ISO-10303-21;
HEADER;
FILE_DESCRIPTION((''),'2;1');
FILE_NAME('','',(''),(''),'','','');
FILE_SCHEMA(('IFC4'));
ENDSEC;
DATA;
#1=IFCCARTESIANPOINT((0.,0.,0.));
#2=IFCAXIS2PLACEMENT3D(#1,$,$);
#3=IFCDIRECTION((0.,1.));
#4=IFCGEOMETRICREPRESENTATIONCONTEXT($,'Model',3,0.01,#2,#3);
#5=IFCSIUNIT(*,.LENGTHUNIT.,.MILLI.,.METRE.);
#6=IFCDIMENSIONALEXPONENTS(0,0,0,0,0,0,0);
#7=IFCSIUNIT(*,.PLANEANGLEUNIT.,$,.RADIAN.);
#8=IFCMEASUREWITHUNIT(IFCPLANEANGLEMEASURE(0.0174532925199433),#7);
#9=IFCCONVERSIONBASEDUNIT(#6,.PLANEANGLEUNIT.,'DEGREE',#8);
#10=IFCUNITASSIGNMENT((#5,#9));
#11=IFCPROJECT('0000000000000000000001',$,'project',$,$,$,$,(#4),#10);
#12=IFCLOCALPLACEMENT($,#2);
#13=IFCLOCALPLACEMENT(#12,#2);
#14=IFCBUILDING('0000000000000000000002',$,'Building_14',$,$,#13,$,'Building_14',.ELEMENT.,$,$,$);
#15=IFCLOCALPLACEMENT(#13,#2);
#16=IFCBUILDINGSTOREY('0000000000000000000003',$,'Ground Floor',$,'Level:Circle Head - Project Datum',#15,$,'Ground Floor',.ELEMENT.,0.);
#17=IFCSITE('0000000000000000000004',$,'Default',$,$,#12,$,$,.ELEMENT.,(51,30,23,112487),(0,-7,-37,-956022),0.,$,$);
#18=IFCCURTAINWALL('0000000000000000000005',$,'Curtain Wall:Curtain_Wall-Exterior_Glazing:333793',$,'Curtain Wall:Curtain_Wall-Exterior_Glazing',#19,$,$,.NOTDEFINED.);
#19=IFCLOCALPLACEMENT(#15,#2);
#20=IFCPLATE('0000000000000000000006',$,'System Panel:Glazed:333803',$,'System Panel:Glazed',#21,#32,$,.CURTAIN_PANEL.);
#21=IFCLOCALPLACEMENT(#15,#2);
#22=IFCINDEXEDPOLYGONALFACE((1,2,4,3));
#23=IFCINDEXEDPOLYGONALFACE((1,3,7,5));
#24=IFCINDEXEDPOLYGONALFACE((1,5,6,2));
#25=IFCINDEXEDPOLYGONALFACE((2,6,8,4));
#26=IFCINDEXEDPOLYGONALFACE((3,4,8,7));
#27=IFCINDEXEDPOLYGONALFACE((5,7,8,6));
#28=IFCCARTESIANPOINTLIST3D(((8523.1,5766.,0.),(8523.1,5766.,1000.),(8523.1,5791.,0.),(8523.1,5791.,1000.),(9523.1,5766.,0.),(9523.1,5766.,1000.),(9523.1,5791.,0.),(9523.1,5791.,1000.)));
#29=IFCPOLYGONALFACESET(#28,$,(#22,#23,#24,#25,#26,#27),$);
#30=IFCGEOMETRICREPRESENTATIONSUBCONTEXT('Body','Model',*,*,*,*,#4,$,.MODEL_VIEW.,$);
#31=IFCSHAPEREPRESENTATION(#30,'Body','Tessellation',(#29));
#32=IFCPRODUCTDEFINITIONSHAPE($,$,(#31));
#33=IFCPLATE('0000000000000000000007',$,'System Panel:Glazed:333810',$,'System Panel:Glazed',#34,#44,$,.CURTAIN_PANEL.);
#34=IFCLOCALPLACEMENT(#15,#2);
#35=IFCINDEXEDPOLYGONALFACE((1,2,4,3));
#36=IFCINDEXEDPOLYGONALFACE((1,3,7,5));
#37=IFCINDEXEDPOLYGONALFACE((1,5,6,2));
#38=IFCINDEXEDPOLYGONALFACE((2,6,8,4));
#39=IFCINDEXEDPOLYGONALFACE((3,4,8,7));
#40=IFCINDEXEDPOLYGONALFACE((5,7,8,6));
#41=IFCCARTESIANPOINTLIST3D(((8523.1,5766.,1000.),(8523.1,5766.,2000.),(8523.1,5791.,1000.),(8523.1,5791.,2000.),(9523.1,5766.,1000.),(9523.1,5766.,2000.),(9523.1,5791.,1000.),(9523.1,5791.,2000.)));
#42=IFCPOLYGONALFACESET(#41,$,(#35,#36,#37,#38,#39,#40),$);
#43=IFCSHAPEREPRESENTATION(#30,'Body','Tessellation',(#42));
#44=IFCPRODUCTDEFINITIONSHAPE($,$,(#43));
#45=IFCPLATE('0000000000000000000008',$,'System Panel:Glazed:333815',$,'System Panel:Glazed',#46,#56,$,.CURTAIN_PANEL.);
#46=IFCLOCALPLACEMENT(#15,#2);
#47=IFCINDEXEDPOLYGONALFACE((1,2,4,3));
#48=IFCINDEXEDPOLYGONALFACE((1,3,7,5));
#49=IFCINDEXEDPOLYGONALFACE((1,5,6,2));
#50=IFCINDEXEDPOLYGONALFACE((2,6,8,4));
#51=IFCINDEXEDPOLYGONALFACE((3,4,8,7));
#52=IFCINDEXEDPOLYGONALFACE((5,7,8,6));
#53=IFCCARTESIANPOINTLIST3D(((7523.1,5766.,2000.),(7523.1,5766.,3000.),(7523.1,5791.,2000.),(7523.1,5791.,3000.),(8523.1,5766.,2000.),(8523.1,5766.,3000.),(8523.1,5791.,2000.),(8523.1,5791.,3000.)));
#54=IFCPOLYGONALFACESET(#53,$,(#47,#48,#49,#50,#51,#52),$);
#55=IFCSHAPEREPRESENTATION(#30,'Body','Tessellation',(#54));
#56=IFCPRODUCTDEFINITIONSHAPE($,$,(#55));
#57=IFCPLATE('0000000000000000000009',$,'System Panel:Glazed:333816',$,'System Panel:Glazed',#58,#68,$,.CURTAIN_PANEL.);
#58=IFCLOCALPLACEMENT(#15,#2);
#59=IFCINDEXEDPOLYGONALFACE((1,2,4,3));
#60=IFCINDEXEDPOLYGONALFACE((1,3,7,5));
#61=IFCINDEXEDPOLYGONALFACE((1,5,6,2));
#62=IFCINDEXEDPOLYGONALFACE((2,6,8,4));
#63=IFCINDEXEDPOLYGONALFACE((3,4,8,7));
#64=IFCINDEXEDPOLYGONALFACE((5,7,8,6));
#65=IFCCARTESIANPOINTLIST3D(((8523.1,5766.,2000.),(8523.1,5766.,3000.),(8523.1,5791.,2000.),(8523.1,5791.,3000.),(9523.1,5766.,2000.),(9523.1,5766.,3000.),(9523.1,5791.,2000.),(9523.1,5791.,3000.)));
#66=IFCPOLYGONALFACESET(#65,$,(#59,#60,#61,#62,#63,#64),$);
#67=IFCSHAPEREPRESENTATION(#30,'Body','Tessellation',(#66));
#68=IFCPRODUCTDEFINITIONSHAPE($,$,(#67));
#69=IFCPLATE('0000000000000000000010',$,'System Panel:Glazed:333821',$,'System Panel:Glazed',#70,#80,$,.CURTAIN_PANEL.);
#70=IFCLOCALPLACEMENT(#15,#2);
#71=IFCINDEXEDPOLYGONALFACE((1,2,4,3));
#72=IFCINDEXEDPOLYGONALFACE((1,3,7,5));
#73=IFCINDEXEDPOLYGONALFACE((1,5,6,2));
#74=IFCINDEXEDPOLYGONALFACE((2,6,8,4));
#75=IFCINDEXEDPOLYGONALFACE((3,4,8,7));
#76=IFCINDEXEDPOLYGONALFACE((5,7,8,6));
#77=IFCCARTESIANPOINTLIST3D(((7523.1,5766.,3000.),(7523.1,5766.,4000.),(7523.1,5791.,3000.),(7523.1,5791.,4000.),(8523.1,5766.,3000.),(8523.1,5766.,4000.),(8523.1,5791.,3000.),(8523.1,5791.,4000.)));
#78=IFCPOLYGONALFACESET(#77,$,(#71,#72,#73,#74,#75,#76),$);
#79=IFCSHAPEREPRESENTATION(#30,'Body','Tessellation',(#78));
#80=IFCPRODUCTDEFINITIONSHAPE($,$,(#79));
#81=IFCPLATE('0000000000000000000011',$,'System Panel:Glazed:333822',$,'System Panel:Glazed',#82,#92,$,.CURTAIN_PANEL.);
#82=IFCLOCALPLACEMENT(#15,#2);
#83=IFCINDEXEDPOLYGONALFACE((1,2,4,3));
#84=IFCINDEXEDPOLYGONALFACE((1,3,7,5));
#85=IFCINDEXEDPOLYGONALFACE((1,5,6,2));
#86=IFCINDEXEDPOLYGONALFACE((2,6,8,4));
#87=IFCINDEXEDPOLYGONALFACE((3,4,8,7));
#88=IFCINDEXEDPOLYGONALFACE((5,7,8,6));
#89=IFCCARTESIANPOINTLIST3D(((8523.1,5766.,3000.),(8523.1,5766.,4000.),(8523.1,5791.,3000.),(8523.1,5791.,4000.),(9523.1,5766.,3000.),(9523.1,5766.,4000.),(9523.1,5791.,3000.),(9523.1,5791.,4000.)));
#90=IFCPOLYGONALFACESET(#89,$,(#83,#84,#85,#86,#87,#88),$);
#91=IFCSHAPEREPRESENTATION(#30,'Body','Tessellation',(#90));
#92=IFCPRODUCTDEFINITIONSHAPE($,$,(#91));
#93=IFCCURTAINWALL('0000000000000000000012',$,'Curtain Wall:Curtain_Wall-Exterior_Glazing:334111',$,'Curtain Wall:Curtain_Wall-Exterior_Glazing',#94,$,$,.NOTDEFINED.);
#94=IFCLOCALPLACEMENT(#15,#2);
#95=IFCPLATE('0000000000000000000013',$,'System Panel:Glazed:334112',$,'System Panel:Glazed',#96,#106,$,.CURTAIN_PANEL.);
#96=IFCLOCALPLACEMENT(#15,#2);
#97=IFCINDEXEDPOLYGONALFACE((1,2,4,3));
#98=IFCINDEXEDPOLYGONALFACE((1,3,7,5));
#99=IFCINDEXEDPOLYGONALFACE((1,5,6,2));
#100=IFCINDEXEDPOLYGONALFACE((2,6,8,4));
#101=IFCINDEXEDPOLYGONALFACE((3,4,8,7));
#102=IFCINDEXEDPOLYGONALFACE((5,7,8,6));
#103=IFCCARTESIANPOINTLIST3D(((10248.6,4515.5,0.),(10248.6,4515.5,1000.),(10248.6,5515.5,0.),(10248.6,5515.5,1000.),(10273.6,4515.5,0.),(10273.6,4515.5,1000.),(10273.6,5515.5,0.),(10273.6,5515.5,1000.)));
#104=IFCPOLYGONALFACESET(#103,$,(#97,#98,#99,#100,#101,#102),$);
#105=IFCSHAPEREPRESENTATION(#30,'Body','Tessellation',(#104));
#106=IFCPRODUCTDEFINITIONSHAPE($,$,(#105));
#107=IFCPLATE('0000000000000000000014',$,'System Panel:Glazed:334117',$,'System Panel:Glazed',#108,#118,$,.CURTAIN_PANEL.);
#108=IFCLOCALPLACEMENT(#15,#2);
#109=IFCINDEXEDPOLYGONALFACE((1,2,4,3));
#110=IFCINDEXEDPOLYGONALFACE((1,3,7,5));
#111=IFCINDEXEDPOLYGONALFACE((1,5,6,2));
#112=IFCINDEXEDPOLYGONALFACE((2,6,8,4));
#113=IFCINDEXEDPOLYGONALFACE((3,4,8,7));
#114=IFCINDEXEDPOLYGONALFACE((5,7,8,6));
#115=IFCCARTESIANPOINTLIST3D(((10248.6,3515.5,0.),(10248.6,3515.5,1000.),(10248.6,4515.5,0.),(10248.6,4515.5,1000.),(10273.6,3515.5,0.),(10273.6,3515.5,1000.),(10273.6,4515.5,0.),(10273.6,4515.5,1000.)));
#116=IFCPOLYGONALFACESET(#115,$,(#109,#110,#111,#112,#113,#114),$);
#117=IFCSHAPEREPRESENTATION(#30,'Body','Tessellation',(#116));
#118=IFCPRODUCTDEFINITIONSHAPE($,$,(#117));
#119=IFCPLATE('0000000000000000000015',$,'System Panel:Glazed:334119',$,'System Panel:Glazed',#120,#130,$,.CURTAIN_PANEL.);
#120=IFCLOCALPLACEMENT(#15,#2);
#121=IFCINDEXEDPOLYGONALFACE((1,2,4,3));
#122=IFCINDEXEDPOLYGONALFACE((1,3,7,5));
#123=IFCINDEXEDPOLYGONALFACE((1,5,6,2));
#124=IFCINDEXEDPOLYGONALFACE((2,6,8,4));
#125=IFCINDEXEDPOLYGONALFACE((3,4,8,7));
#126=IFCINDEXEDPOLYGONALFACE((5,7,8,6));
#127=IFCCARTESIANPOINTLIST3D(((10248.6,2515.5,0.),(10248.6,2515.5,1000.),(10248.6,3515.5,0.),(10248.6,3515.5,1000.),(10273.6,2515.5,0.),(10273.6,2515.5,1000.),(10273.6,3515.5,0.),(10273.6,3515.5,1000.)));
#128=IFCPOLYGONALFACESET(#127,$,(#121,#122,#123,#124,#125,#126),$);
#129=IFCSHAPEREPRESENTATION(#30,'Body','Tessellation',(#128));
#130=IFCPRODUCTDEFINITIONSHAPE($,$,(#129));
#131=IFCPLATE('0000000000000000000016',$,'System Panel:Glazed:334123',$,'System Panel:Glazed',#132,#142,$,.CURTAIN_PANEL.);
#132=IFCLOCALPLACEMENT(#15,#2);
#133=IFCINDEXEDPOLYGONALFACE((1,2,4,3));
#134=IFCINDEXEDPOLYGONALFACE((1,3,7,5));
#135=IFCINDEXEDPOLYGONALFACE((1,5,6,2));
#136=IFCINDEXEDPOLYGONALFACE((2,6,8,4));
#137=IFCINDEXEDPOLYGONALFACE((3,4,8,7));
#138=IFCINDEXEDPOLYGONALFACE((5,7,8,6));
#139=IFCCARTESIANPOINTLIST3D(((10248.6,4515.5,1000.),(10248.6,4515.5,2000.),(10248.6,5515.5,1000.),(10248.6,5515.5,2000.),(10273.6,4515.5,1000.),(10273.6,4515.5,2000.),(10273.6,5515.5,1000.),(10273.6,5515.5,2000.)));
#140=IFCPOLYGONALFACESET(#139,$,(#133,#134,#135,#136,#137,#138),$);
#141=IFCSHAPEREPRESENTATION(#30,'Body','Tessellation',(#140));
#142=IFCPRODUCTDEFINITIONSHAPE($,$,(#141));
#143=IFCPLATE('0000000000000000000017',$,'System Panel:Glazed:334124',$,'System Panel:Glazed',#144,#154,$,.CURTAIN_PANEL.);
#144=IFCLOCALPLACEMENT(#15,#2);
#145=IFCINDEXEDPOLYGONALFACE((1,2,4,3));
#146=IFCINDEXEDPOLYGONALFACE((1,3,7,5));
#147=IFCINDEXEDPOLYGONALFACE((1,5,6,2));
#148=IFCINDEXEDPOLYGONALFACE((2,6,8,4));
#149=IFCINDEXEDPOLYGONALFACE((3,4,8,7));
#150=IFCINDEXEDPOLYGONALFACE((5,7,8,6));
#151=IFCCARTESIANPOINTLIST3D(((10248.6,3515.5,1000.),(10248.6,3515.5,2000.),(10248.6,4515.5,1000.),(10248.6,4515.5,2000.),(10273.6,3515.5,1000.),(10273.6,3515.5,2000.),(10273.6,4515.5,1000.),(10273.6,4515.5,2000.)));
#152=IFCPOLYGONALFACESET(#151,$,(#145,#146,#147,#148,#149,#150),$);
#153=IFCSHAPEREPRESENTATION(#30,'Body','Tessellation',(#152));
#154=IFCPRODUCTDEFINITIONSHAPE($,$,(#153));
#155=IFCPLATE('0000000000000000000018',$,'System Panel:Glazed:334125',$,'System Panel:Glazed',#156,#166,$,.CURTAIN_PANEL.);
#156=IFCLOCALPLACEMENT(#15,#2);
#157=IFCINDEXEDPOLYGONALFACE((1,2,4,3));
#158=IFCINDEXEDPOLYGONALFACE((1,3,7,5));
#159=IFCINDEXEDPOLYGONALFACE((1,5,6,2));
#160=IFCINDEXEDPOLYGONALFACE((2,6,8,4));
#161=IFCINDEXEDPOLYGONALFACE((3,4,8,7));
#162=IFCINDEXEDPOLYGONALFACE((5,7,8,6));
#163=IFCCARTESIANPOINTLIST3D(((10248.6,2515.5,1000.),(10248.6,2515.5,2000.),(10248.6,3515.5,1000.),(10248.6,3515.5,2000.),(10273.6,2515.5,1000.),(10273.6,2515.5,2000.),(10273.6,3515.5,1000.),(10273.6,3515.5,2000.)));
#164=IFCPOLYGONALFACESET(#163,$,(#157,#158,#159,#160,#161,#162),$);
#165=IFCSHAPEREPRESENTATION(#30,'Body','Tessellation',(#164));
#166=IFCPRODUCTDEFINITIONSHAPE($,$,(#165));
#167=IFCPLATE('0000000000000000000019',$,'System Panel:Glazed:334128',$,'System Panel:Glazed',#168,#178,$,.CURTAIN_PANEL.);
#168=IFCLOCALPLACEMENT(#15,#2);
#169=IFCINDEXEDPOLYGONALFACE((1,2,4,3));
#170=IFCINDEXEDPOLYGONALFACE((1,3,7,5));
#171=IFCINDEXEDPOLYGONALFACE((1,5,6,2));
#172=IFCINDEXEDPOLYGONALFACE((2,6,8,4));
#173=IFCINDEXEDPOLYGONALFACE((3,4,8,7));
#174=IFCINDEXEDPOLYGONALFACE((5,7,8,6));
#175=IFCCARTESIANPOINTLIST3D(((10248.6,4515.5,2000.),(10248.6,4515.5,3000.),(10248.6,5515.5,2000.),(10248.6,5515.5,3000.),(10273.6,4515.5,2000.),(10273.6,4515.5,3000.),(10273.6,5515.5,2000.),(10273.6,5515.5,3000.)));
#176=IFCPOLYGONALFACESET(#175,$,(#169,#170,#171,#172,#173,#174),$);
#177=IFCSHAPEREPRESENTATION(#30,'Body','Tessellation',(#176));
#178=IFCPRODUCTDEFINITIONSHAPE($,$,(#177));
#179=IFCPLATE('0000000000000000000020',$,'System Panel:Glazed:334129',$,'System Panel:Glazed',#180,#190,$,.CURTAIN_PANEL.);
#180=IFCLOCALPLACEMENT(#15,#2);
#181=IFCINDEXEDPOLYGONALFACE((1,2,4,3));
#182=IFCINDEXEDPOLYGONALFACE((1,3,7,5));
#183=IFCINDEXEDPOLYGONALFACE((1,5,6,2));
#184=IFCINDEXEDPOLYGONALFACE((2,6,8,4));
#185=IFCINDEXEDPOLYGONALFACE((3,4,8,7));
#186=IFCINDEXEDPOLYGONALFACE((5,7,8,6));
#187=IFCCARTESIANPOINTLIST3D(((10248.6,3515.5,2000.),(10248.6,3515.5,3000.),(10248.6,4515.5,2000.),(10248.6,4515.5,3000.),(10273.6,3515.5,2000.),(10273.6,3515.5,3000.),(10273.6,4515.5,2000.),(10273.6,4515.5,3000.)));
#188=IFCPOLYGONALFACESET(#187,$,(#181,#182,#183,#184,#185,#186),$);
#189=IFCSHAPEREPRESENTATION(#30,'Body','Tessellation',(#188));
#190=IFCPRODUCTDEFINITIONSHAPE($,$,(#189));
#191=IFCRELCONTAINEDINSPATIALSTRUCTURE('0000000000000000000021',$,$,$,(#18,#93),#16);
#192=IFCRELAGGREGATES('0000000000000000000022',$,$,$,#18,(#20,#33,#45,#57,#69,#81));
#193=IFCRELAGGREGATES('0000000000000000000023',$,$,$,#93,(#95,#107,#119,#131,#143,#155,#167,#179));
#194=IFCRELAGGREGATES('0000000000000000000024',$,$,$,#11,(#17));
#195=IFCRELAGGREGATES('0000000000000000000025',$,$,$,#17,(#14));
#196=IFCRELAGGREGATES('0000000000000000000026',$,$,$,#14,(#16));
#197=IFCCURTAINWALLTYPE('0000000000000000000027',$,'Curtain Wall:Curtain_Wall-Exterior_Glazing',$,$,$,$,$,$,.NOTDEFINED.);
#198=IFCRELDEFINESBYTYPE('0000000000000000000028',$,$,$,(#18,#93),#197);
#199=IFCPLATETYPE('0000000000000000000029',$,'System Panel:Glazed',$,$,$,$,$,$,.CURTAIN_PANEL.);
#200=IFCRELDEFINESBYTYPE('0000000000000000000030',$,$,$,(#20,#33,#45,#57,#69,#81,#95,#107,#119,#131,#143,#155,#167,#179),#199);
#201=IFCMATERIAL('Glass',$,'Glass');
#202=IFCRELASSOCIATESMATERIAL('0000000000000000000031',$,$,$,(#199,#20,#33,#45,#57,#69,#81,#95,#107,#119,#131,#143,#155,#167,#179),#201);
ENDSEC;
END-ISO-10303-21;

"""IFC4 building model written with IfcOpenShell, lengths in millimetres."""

from ifc_helpers import new_model, entity, si_unit, converted_unit, direction, frame, origin, place, context, subcontext, project, spatial, indexed_curve, outline, extrude, source, transform, mapped, material, type_object, type_shapes, element, aggregate, save


model = new_model("IFC4")

# Units and contexts
model_context = context("Model", 3, precision=0.01, world=origin(), true_north=direction((0.0, 1.0)))
body_context = subcontext(model_context, "Body", "Model", "MODEL_VIEW")
ifc_project = project(units=[si_unit("LENGTHUNIT", "METRE", prefix="MILLI"), converted_unit("PLANEANGLEUNIT", "DEGREE", entity("IfcPlaneAngleMeasure", 0.0174532925199433), si_unit("PLANEANGLEUNIT", "RADIAN"), dimensions=[0, 0, 0, 0, 0, 0, 0])], contexts=[model_context])

# Site, building, storey
site_placement = place(None, origin())
site = spatial("IfcSite", under=ifc_project, at=site_placement, Name="Default", CompositionType="ELEMENT", RefLatitude=(51, 30, 23, 112487), RefLongitude=(0, -7, -37, -956022), RefElevation=0.0)
building_placement = place(site_placement, origin())
building = spatial("IfcBuilding", under=site, at=building_placement, Name="Building_14", LongName="Building_14", CompositionType="ELEMENT")
storey_placement = place(building_placement, origin())
storey = spatial("IfcBuildingStorey", under=building, at=storey_placement, Name="Ground Floor", ObjectType="Level:Circle Head - Project Datum", LongName="Ground Floor", CompositionType="ELEMENT", Elevation=0.0)

# Curtain walls, plates
curtain_wall_type = type_object("IfcCurtainWallType", Name="Curtain Wall:Curtain_Wall-Exterior_Glazing", PredefinedType="NOTDEFINED")
curtain_wall_1_placement = place(storey_placement, origin())
curtain_wall_1 = element("IfcCurtainWall", 1, at=curtain_wall_1_placement, inside=storey, type_object=curtain_wall_type, Name="Curtain Wall:Curtain_Wall-Exterior_Glazing:333793", ObjectType="Curtain Wall:Curtain_Wall-Exterior_Glazing", PredefinedType="NOTDEFINED")
ifc_material = material(Name="Glass", Category="Glass")
plate_type_1 = type_object("IfcPlateType", Name="System Panel:Glazed", PredefinedType="CURTAIN_PANEL", material=ifc_material)
shared_shape_1 = source(origin(), body_context, "Body", "SweptSolid", [
    extrude(outline(indexed_curve([(-12.5, -500.0), (12.5, -500.0), (12.5, 500.0), (-12.5, 500.0), (-12.5, -500.0)], self_intersect=False)), frame((0.0, -37.0, 0.0), z_axis=(0.0, 0.0, 1.0), x_axis=(0.0, 1.0, 0.0)), (0.0, 0.0, 1.0), 1000.0),
])
type_shapes(plate_type_1, [shared_shape_1])
plate_1_placement = place(curtain_wall_1_placement, frame((9023.1, 5815.5, 0.0)))
plate_1 = element("IfcPlate", 2, at=plate_1_placement, type_object=plate_type_1, material=ifc_material, Name="System Panel:Glazed:333803", ObjectType="System Panel:Glazed", PredefinedType="CURTAIN_PANEL", context=body_context, shape_type="MappedRepresentation", body=[
    mapped(shared_shape_1, transform((0.0, 0.0, 0.0), scale=1.0)),
])
plate_2_placement = place(curtain_wall_1_placement, frame((9023.1, 5815.5, 1000.0)))
plate_2 = element("IfcPlate", 3, at=plate_2_placement, type_object=plate_type_1, material=ifc_material, Name="System Panel:Glazed:333810", ObjectType="System Panel:Glazed", PredefinedType="CURTAIN_PANEL", context=body_context, shape_type="MappedRepresentation", body=[
    mapped(shared_shape_1, transform((0.0, 0.0, 0.0), scale=1.0)),
])
plate_3_placement = place(curtain_wall_1_placement, frame((8023.1, 5815.5, 2000.0)))
plate_3 = element("IfcPlate", 4, at=plate_3_placement, type_object=plate_type_1, material=ifc_material, Name="System Panel:Glazed:333815", ObjectType="System Panel:Glazed", PredefinedType="CURTAIN_PANEL", context=body_context, shape_type="MappedRepresentation", body=[
    mapped(shared_shape_1, transform((0.0, 0.0, 0.0), scale=1.0)),
])
plate_4_placement = place(curtain_wall_1_placement, frame((9023.1, 5815.5, 2000.0)))
plate_4 = element("IfcPlate", 5, at=plate_4_placement, type_object=plate_type_1, material=ifc_material, Name="System Panel:Glazed:333816", ObjectType="System Panel:Glazed", PredefinedType="CURTAIN_PANEL", context=body_context, shape_type="MappedRepresentation", body=[
    mapped(shared_shape_1, transform((0.0, 0.0, 0.0), scale=1.0)),
])
plate_5_placement = place(curtain_wall_1_placement, frame((8023.1, 5815.5, 3000.0)))
plate_5 = element("IfcPlate", 6, at=plate_5_placement, type_object=plate_type_1, material=ifc_material, Name="System Panel:Glazed:333821", ObjectType="System Panel:Glazed", PredefinedType="CURTAIN_PANEL", context=body_context, shape_type="MappedRepresentation", body=[
    mapped(shared_shape_1, transform((0.0, 0.0, 0.0), scale=1.0)),
])
plate_6_placement = place(curtain_wall_1_placement, frame((9023.1, 5815.5, 3000.0)))
plate_6 = element("IfcPlate", 7, at=plate_6_placement, type_object=plate_type_1, material=ifc_material, Name="System Panel:Glazed:333822", ObjectType="System Panel:Glazed", PredefinedType="CURTAIN_PANEL", context=body_context, shape_type="MappedRepresentation", body=[
    mapped(shared_shape_1, transform((0.0, 0.0, 0.0), scale=1.0)),
])
curtain_wall_2_placement = place(storey_placement, origin())
curtain_wall_2 = element("IfcCurtainWall", 8, at=curtain_wall_2_placement, inside=storey, type_object=curtain_wall_type, Name="Curtain Wall:Curtain_Wall-Exterior_Glazing:334111", ObjectType="Curtain Wall:Curtain_Wall-Exterior_Glazing", PredefinedType="NOTDEFINED")
plate_7_placement = place(curtain_wall_2_placement, frame((10298.1, 5015.5, 0.0), z_axis=(0.0, 0.0, 1.0), x_axis=(0.0, -1.0, 0.0)))
plate_7 = element("IfcPlate", 9, at=plate_7_placement, type_object=plate_type_1, material=ifc_material, Name="System Panel:Glazed:334112", ObjectType="System Panel:Glazed", PredefinedType="CURTAIN_PANEL", context=body_context, shape_type="MappedRepresentation", body=[
    mapped(shared_shape_1, transform((0.0, 0.0, 0.0), scale=1.0)),
])
plate_8_placement = place(curtain_wall_2_placement, frame((10298.1, 4015.5, 0.0), z_axis=(0.0, 0.0, 1.0), x_axis=(0.0, -1.0, 0.0)))
plate_8 = element("IfcPlate", 10, at=plate_8_placement, type_object=plate_type_1, material=ifc_material, Name="System Panel:Glazed:334117", ObjectType="System Panel:Glazed", PredefinedType="CURTAIN_PANEL", context=body_context, shape_type="MappedRepresentation", body=[
    mapped(shared_shape_1, transform((0.0, 0.0, 0.0), scale=1.0)),
])
plate_9_placement = place(curtain_wall_2_placement, frame((10298.1, 3015.5, 0.0), z_axis=(0.0, 0.0, 1.0), x_axis=(0.0, -1.0, 0.0)))
plate_9 = element("IfcPlate", 11, at=plate_9_placement, type_object=plate_type_1, material=ifc_material, Name="System Panel:Glazed:334119", ObjectType="System Panel:Glazed", PredefinedType="CURTAIN_PANEL", context=body_context, shape_type="MappedRepresentation", body=[
    mapped(shared_shape_1, transform((0.0, 0.0, 0.0), scale=1.0)),
])
plate_10_placement = place(curtain_wall_2_placement, frame((10298.1, 5015.5, 1000.0), z_axis=(0.0, 0.0, 1.0), x_axis=(0.0, -1.0, 0.0)))
plate_10 = element("IfcPlate", 12, at=plate_10_placement, type_object=plate_type_1, material=ifc_material, Name="System Panel:Glazed:334123", ObjectType="System Panel:Glazed", PredefinedType="CURTAIN_PANEL", context=body_context, shape_type="MappedRepresentation", body=[
    mapped(shared_shape_1, transform((0.0, 0.0, 0.0), scale=1.0)),
])
plate_11_placement = place(curtain_wall_2_placement, frame((10298.1, 4015.5, 1000.0), z_axis=(0.0, 0.0, 1.0), x_axis=(0.0, -1.0, 0.0)))
plate_11 = element("IfcPlate", 13, at=plate_11_placement, type_object=plate_type_1, material=ifc_material, Name="System Panel:Glazed:334124", ObjectType="System Panel:Glazed", PredefinedType="CURTAIN_PANEL", context=body_context, shape_type="MappedRepresentation", body=[
    mapped(shared_shape_1, transform((0.0, 0.0, 0.0), scale=1.0)),
])
plate_12_placement = place(curtain_wall_2_placement, frame((10298.1, 3015.5, 1000.0), z_axis=(0.0, 0.0, 1.0), x_axis=(0.0, -1.0, 0.0)))
plate_12 = element("IfcPlate", 14, at=plate_12_placement, type_object=plate_type_1, material=ifc_material, Name="System Panel:Glazed:334125", ObjectType="System Panel:Glazed", PredefinedType="CURTAIN_PANEL", context=body_context, shape_type="MappedRepresentation", body=[
    mapped(shared_shape_1, transform((0.0, 0.0, 0.0), scale=1.0)),
])
plate_13_placement = place(curtain_wall_2_placement, frame((10298.1, 5015.5, 2000.0), z_axis=(0.0, 0.0, 1.0), x_axis=(0.0, -1.0, 0.0)))
plate_13 = element("IfcPlate", 15, at=plate_13_placement, type_object=plate_type_1, material=ifc_material, Name="System Panel:Glazed:334128", ObjectType="System Panel:Glazed", PredefinedType="CURTAIN_PANEL", context=body_context, shape_type="MappedRepresentation", body=[
    mapped(shared_shape_1, transform((0.0, 0.0, 0.0), scale=1.0)),
])
plate_14_placement = place(curtain_wall_2_placement, frame((10298.1, 4015.5, 2000.0), z_axis=(0.0, 0.0, 1.0), x_axis=(0.0, -1.0, 0.0)))
plate_14 = element("IfcPlate", 16, at=plate_14_placement, type_object=plate_type_1, material=ifc_material, Name="System Panel:Glazed:334129", ObjectType="System Panel:Glazed", PredefinedType="CURTAIN_PANEL", context=body_context, shape_type="MappedRepresentation", body=[
    mapped(shared_shape_1, transform((0.0, 0.0, 0.0), scale=1.0)),
])

aggregate(curtain_wall_1, [plate_1, plate_2, plate_3, plate_4, plate_5, plate_6])
aggregate(curtain_wall_2, [plate_7, plate_8, plate_9, plate_10, plate_11, plate_12, plate_13, plate_14])

save(model, "model.ifc")
